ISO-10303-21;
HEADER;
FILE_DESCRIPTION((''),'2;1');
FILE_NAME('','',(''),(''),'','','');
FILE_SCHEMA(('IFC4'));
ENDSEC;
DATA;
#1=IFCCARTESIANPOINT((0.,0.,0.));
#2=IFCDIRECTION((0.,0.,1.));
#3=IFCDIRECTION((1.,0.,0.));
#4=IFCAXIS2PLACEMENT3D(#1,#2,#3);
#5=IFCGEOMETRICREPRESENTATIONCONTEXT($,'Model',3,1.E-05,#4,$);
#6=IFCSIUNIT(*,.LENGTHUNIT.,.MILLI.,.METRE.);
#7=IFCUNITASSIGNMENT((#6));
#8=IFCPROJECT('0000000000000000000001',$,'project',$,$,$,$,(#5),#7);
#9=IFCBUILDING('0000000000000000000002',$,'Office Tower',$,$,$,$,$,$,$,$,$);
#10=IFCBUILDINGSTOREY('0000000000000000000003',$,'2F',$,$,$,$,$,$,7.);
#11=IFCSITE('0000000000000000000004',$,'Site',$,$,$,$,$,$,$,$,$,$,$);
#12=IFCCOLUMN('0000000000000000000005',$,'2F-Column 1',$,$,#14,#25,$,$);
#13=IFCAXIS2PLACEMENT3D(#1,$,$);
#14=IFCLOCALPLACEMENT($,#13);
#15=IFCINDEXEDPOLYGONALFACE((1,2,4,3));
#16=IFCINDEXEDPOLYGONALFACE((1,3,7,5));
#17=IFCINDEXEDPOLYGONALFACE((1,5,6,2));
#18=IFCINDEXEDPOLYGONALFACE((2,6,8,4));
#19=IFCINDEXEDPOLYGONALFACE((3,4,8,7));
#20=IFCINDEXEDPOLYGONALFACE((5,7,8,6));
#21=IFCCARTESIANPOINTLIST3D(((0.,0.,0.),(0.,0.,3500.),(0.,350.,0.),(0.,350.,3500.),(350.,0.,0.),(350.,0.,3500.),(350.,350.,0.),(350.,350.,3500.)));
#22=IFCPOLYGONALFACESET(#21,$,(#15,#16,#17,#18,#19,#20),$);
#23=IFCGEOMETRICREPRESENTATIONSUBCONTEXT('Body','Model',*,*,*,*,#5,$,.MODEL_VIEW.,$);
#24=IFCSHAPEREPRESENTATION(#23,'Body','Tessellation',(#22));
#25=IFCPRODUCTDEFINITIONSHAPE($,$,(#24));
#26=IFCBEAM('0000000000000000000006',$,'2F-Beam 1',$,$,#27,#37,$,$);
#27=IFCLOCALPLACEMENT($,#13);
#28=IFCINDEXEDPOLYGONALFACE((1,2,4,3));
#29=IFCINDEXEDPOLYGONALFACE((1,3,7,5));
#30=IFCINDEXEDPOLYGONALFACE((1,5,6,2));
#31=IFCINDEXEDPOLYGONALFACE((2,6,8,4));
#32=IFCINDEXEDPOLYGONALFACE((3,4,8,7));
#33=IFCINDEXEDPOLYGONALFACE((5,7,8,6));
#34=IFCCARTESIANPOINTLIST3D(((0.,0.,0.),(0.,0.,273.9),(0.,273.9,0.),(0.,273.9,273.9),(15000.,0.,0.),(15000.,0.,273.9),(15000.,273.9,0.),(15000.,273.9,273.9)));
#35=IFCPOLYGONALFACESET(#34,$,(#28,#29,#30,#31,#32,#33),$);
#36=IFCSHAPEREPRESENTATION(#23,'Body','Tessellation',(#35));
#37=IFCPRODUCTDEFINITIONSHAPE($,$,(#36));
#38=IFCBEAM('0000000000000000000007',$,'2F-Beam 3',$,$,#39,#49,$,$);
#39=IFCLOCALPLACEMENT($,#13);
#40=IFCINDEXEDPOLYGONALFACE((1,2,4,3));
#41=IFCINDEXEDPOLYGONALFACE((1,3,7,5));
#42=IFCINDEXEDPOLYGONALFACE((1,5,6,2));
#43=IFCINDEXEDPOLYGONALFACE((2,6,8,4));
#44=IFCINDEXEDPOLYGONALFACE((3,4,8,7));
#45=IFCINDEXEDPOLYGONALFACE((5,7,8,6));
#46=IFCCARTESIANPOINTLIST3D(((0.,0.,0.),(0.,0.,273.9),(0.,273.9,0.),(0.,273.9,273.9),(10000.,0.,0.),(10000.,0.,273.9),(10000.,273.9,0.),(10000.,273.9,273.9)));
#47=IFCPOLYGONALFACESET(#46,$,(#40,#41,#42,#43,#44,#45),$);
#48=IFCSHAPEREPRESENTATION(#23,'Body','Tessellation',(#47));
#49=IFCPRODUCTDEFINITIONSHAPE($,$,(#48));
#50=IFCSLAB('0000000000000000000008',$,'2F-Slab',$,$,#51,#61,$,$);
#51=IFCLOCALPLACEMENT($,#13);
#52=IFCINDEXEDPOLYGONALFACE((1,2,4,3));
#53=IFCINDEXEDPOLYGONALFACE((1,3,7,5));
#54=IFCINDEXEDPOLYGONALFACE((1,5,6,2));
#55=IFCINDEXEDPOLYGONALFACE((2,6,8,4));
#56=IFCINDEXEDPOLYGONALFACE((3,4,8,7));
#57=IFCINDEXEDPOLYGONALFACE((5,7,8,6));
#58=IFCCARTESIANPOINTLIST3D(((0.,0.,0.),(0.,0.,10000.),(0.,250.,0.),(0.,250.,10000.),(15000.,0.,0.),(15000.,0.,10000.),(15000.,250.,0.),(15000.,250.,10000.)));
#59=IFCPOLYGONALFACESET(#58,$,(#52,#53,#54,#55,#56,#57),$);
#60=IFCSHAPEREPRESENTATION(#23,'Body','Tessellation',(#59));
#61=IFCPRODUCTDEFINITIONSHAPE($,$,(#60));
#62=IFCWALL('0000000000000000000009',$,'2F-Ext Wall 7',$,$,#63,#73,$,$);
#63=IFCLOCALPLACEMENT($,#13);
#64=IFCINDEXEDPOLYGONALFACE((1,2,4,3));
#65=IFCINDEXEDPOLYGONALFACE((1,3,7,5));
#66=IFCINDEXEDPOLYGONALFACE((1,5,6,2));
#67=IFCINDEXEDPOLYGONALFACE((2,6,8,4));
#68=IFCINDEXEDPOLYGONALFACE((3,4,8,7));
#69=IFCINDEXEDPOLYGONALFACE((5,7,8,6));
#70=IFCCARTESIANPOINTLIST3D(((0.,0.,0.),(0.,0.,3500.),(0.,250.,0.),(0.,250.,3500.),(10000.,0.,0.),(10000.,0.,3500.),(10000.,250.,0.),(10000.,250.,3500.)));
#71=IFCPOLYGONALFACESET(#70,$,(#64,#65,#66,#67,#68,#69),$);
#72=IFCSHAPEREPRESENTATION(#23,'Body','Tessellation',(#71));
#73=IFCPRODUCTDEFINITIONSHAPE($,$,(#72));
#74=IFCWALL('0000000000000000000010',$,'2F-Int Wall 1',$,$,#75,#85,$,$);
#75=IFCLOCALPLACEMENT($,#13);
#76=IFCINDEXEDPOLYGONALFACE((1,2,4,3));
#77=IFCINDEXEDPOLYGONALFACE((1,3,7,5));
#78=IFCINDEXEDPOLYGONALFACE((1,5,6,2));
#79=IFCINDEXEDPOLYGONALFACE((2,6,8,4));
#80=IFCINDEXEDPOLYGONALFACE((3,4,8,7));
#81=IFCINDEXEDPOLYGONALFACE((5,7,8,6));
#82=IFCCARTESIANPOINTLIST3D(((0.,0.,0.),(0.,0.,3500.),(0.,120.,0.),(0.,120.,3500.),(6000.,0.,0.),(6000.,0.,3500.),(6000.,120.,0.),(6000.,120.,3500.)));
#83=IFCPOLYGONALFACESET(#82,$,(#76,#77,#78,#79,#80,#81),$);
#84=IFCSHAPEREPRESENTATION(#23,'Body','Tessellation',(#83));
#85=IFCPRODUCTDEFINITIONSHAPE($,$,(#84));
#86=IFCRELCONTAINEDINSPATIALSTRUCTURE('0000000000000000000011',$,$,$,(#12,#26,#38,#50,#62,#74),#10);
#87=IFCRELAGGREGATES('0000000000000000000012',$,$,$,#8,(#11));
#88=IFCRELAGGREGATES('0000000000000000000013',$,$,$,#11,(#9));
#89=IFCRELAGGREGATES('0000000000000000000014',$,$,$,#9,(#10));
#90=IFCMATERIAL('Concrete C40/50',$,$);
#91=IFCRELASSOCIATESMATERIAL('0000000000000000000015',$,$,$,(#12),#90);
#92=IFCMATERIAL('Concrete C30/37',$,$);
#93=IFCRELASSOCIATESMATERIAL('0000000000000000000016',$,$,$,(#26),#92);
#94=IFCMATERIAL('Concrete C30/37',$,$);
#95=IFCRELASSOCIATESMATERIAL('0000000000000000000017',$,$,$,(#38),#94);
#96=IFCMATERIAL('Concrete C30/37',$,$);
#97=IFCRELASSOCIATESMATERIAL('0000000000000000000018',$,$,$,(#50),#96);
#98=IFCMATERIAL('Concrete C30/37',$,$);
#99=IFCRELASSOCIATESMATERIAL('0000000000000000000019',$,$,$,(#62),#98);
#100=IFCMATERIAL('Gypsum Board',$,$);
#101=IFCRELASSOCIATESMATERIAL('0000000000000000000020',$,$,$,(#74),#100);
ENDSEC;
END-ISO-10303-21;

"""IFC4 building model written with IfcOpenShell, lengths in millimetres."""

from ifc_helpers import new_model, si_unit, origin_with_axes, context, subcontext, project, spatial, indexed_curve, outline, extrude, material, element, save


model = new_model("IFC4")

# Units and contexts
model_context = context("Model", 3, precision=1e-05, world=origin_with_axes())
body_context = subcontext(model_context, "Body", "Model", "MODEL_VIEW")
ifc_project = project(units=[si_unit("LENGTHUNIT", "METRE", prefix="MILLI")], contexts=[model_context])

# Site, building, storey
site = spatial("IfcSite", under=ifc_project, Name="Site")
building = spatial("IfcBuilding", under=site, Name="Office Tower")
storey = spatial("IfcBuildingStorey", under=building, Name="2F", Elevation=7.0)

# Column
ifc_material_1 = material(Name="Concrete C40/50")
element("IfcColumn", 1, inside=storey, material=ifc_material_1, Name="2F-Column 1", context=body_context, shape_type="SweptSolid", body=[
    extrude(outline(indexed_curve([(0.0, 0.0), (0.0, 350.0), (350.0, 350.0), (350.0, 0.0), (0.0, 0.0)], self_intersect=False)), origin_with_axes(), (0.0, 0.0, 1.0), 3500.0),
])

# Beams
ifc_material_2 = material(Name="Concrete C30/37")
element("IfcBeam", 2, inside=storey, material=ifc_material_2, Name="2F-Beam 1", context=body_context, shape_type="SweptSolid", body=[
    extrude(outline(indexed_curve([(0.0, 0.0), (0.0, 273.9), (15000.0, 273.9), (15000.0, 0.0), (0.0, 0.0)], self_intersect=False)), origin_with_axes(), (0.0, 0.0, 1.0), 273.9),
])
ifc_material_3 = material(Name="Concrete C30/37")
element("IfcBeam", 3, inside=storey, material=ifc_material_3, Name="2F-Beam 3", context=body_context, shape_type="SweptSolid", body=[
    extrude(outline(indexed_curve([(0.0, 0.0), (0.0, 273.9), (10000.0, 273.9), (10000.0, 0.0), (0.0, 0.0)], self_intersect=False)), origin_with_axes(), (0.0, 0.0, 1.0), 273.9),
])

# Slab
ifc_material_4 = material(Name="Concrete C30/37")
element("IfcSlab", 4, inside=storey, material=ifc_material_4, Name="2F-Slab", context=body_context, shape_type="SweptSolid", body=[
    extrude(outline(indexed_curve([(0.0, 0.0), (0.0, 250.0), (15000.0, 250.0), (15000.0, 0.0), (0.0, 0.0)], self_intersect=False)), origin_with_axes(), (0.0, 0.0, 1.0), 10000.0),
])

# Walls
ifc_material_5 = material(Name="Concrete C30/37")
element("IfcWall", 5, inside=storey, material=ifc_material_5, Name="2F-Ext Wall 7", context=body_context, shape_type="SweptSolid", body=[
    extrude(outline(indexed_curve([(0.0, 0.0), (0.0, 250.0), (10000.0, 250.0), (10000.0, 0.0), (0.0, 0.0)], self_intersect=False)), origin_with_axes(), (0.0, 0.0, 1.0), 3500.0),
])
ifc_material_6 = material(Name="Gypsum Board")
element("IfcWall", 6, inside=storey, material=ifc_material_6, Name="2F-Int Wall 1", context=body_context, shape_type="SweptSolid", body=[
    extrude(outline(indexed_curve([(0.0, 0.0), (0.0, 120.0), (6000.0, 120.0), (6000.0, 0.0), (0.0, 0.0)], self_intersect=False)), origin_with_axes(), (0.0, 0.0, 1.0), 3500.0),
])

save(model, "model.ifc")
